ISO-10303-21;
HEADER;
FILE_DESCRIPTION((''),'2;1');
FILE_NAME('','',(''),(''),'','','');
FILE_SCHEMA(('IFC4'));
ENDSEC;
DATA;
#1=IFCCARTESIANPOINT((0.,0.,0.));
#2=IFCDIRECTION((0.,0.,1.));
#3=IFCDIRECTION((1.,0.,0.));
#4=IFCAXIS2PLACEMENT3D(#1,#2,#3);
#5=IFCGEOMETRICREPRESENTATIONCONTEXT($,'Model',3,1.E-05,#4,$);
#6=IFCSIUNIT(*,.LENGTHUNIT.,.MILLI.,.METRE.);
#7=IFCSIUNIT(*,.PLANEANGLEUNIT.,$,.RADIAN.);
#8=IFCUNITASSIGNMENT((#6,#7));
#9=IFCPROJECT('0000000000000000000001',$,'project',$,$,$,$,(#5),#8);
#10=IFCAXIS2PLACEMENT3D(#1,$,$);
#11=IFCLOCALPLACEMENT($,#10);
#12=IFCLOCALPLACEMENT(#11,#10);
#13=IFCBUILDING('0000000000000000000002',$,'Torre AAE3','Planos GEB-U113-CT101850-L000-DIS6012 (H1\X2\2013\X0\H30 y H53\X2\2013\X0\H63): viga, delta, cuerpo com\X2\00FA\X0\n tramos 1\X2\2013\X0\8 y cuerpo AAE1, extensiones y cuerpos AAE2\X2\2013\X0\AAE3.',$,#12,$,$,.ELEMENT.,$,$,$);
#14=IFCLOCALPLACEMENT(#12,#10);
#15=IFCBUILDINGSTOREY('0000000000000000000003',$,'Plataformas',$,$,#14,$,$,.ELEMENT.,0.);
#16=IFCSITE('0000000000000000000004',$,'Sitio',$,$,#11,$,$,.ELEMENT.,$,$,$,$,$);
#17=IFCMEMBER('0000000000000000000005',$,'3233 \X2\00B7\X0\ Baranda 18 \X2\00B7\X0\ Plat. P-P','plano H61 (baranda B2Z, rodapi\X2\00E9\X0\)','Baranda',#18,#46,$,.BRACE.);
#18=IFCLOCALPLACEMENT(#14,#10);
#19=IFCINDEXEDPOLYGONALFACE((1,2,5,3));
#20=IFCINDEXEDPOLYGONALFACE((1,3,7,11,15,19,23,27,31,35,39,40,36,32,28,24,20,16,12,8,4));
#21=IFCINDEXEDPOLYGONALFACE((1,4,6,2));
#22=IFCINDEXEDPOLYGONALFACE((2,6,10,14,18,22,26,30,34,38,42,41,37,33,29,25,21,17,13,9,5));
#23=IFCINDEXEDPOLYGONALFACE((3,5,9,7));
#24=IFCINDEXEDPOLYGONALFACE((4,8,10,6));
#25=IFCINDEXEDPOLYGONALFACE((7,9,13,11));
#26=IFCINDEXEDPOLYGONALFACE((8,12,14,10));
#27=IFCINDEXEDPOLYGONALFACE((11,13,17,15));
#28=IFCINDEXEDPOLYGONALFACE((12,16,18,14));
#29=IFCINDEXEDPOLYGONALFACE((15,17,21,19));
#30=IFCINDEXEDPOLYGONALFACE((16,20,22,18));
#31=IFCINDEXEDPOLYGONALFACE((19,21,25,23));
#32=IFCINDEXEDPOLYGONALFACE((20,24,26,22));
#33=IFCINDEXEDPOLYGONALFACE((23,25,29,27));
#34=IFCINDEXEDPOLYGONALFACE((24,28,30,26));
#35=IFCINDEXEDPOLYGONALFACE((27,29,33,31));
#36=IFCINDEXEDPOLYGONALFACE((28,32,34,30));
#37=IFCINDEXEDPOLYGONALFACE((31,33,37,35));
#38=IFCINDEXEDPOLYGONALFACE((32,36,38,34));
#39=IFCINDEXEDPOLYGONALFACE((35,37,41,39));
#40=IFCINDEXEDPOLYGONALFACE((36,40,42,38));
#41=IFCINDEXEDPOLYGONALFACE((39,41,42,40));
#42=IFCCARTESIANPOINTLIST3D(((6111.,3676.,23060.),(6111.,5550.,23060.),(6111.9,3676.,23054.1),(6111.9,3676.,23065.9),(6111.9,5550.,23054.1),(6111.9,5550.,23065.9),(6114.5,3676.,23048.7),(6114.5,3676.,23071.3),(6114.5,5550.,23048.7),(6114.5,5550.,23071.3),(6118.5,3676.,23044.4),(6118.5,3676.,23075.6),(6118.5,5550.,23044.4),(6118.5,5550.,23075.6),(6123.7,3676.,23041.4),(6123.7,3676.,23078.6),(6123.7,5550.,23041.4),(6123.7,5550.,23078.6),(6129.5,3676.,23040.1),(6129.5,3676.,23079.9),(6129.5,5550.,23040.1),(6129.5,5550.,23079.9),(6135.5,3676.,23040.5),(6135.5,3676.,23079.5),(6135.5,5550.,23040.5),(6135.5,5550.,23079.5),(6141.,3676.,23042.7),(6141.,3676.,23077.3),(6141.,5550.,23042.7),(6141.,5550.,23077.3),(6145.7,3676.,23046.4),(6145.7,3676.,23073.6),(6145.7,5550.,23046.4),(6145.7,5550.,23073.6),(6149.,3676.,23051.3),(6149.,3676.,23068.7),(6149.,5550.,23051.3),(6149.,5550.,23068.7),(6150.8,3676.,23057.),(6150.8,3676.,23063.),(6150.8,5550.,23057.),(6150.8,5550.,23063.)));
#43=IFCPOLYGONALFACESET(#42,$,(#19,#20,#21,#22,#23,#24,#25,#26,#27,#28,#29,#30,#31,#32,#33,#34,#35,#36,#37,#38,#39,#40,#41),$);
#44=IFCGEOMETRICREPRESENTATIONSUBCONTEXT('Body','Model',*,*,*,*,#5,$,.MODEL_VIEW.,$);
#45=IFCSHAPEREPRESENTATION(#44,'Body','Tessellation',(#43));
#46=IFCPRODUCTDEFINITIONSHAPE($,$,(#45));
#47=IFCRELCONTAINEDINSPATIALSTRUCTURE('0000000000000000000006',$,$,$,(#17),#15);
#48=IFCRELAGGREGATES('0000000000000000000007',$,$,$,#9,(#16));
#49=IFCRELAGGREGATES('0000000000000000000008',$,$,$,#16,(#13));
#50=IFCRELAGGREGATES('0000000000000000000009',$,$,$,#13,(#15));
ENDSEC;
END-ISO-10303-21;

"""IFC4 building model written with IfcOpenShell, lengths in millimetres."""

from ifc_helpers import new_model, si_unit, frame, origin, origin_with_axes, place, context, subcontext, project, spatial, circle, extrude, element, save


model = new_model("IFC4")

# Units and contexts
model_context = context("Model", 3, precision=1e-05, world=origin_with_axes())
body_context = subcontext(model_context, "Body", "Model", "MODEL_VIEW")
ifc_project = project(units=[si_unit("LENGTHUNIT", "METRE", prefix="MILLI"), si_unit("PLANEANGLEUNIT", "RADIAN")], contexts=[model_context])

# Site, building, storey
site_placement = place(None, origin())
site = spatial("IfcSite", under=ifc_project, at=site_placement, Name="Sitio", CompositionType="ELEMENT")
building_placement = place(site_placement, origin())
building = spatial("IfcBuilding", under=site, at=building_placement, Name="Torre AAE3", Description="Planos GEB-U113-CT101850-L000-DIS6012 (H1–H30 y H53–H63): viga, delta, cuerpo común tramos 1–8 y cuerpo AAE1, extensiones y cuerpos AAE2–AAE3.", CompositionType="ELEMENT")
storey_placement = place(building_placement, origin())
storey = spatial("IfcBuildingStorey", under=building, at=storey_placement, Name="Plataformas", CompositionType="ELEMENT", Elevation=0.0)

# Member
for number, where, z_axis, x_axis, name in (
    (1, (6131.0, 3676.0, 23060.0), (0.0, 1.0, 0.0), (-1.0, 0.0, 0.0), "3233 · Baranda 18 · Plat. P-P"),
):
    element("IfcMember", number, at=place(storey_placement, frame(where, z_axis=z_axis, x_axis=x_axis)), inside=storey, Name=name, Description="plano H61 (baranda B2Z, rodapié)", ObjectType="Baranda", PredefinedType="BRACE", context=body_context, shape_type="SweptSolid", body=[
        extrude(circle(Radius=20.0), None, (0.0, 0.0, 1.0), 1874.0),
    ])

save(model, "model.ifc")
